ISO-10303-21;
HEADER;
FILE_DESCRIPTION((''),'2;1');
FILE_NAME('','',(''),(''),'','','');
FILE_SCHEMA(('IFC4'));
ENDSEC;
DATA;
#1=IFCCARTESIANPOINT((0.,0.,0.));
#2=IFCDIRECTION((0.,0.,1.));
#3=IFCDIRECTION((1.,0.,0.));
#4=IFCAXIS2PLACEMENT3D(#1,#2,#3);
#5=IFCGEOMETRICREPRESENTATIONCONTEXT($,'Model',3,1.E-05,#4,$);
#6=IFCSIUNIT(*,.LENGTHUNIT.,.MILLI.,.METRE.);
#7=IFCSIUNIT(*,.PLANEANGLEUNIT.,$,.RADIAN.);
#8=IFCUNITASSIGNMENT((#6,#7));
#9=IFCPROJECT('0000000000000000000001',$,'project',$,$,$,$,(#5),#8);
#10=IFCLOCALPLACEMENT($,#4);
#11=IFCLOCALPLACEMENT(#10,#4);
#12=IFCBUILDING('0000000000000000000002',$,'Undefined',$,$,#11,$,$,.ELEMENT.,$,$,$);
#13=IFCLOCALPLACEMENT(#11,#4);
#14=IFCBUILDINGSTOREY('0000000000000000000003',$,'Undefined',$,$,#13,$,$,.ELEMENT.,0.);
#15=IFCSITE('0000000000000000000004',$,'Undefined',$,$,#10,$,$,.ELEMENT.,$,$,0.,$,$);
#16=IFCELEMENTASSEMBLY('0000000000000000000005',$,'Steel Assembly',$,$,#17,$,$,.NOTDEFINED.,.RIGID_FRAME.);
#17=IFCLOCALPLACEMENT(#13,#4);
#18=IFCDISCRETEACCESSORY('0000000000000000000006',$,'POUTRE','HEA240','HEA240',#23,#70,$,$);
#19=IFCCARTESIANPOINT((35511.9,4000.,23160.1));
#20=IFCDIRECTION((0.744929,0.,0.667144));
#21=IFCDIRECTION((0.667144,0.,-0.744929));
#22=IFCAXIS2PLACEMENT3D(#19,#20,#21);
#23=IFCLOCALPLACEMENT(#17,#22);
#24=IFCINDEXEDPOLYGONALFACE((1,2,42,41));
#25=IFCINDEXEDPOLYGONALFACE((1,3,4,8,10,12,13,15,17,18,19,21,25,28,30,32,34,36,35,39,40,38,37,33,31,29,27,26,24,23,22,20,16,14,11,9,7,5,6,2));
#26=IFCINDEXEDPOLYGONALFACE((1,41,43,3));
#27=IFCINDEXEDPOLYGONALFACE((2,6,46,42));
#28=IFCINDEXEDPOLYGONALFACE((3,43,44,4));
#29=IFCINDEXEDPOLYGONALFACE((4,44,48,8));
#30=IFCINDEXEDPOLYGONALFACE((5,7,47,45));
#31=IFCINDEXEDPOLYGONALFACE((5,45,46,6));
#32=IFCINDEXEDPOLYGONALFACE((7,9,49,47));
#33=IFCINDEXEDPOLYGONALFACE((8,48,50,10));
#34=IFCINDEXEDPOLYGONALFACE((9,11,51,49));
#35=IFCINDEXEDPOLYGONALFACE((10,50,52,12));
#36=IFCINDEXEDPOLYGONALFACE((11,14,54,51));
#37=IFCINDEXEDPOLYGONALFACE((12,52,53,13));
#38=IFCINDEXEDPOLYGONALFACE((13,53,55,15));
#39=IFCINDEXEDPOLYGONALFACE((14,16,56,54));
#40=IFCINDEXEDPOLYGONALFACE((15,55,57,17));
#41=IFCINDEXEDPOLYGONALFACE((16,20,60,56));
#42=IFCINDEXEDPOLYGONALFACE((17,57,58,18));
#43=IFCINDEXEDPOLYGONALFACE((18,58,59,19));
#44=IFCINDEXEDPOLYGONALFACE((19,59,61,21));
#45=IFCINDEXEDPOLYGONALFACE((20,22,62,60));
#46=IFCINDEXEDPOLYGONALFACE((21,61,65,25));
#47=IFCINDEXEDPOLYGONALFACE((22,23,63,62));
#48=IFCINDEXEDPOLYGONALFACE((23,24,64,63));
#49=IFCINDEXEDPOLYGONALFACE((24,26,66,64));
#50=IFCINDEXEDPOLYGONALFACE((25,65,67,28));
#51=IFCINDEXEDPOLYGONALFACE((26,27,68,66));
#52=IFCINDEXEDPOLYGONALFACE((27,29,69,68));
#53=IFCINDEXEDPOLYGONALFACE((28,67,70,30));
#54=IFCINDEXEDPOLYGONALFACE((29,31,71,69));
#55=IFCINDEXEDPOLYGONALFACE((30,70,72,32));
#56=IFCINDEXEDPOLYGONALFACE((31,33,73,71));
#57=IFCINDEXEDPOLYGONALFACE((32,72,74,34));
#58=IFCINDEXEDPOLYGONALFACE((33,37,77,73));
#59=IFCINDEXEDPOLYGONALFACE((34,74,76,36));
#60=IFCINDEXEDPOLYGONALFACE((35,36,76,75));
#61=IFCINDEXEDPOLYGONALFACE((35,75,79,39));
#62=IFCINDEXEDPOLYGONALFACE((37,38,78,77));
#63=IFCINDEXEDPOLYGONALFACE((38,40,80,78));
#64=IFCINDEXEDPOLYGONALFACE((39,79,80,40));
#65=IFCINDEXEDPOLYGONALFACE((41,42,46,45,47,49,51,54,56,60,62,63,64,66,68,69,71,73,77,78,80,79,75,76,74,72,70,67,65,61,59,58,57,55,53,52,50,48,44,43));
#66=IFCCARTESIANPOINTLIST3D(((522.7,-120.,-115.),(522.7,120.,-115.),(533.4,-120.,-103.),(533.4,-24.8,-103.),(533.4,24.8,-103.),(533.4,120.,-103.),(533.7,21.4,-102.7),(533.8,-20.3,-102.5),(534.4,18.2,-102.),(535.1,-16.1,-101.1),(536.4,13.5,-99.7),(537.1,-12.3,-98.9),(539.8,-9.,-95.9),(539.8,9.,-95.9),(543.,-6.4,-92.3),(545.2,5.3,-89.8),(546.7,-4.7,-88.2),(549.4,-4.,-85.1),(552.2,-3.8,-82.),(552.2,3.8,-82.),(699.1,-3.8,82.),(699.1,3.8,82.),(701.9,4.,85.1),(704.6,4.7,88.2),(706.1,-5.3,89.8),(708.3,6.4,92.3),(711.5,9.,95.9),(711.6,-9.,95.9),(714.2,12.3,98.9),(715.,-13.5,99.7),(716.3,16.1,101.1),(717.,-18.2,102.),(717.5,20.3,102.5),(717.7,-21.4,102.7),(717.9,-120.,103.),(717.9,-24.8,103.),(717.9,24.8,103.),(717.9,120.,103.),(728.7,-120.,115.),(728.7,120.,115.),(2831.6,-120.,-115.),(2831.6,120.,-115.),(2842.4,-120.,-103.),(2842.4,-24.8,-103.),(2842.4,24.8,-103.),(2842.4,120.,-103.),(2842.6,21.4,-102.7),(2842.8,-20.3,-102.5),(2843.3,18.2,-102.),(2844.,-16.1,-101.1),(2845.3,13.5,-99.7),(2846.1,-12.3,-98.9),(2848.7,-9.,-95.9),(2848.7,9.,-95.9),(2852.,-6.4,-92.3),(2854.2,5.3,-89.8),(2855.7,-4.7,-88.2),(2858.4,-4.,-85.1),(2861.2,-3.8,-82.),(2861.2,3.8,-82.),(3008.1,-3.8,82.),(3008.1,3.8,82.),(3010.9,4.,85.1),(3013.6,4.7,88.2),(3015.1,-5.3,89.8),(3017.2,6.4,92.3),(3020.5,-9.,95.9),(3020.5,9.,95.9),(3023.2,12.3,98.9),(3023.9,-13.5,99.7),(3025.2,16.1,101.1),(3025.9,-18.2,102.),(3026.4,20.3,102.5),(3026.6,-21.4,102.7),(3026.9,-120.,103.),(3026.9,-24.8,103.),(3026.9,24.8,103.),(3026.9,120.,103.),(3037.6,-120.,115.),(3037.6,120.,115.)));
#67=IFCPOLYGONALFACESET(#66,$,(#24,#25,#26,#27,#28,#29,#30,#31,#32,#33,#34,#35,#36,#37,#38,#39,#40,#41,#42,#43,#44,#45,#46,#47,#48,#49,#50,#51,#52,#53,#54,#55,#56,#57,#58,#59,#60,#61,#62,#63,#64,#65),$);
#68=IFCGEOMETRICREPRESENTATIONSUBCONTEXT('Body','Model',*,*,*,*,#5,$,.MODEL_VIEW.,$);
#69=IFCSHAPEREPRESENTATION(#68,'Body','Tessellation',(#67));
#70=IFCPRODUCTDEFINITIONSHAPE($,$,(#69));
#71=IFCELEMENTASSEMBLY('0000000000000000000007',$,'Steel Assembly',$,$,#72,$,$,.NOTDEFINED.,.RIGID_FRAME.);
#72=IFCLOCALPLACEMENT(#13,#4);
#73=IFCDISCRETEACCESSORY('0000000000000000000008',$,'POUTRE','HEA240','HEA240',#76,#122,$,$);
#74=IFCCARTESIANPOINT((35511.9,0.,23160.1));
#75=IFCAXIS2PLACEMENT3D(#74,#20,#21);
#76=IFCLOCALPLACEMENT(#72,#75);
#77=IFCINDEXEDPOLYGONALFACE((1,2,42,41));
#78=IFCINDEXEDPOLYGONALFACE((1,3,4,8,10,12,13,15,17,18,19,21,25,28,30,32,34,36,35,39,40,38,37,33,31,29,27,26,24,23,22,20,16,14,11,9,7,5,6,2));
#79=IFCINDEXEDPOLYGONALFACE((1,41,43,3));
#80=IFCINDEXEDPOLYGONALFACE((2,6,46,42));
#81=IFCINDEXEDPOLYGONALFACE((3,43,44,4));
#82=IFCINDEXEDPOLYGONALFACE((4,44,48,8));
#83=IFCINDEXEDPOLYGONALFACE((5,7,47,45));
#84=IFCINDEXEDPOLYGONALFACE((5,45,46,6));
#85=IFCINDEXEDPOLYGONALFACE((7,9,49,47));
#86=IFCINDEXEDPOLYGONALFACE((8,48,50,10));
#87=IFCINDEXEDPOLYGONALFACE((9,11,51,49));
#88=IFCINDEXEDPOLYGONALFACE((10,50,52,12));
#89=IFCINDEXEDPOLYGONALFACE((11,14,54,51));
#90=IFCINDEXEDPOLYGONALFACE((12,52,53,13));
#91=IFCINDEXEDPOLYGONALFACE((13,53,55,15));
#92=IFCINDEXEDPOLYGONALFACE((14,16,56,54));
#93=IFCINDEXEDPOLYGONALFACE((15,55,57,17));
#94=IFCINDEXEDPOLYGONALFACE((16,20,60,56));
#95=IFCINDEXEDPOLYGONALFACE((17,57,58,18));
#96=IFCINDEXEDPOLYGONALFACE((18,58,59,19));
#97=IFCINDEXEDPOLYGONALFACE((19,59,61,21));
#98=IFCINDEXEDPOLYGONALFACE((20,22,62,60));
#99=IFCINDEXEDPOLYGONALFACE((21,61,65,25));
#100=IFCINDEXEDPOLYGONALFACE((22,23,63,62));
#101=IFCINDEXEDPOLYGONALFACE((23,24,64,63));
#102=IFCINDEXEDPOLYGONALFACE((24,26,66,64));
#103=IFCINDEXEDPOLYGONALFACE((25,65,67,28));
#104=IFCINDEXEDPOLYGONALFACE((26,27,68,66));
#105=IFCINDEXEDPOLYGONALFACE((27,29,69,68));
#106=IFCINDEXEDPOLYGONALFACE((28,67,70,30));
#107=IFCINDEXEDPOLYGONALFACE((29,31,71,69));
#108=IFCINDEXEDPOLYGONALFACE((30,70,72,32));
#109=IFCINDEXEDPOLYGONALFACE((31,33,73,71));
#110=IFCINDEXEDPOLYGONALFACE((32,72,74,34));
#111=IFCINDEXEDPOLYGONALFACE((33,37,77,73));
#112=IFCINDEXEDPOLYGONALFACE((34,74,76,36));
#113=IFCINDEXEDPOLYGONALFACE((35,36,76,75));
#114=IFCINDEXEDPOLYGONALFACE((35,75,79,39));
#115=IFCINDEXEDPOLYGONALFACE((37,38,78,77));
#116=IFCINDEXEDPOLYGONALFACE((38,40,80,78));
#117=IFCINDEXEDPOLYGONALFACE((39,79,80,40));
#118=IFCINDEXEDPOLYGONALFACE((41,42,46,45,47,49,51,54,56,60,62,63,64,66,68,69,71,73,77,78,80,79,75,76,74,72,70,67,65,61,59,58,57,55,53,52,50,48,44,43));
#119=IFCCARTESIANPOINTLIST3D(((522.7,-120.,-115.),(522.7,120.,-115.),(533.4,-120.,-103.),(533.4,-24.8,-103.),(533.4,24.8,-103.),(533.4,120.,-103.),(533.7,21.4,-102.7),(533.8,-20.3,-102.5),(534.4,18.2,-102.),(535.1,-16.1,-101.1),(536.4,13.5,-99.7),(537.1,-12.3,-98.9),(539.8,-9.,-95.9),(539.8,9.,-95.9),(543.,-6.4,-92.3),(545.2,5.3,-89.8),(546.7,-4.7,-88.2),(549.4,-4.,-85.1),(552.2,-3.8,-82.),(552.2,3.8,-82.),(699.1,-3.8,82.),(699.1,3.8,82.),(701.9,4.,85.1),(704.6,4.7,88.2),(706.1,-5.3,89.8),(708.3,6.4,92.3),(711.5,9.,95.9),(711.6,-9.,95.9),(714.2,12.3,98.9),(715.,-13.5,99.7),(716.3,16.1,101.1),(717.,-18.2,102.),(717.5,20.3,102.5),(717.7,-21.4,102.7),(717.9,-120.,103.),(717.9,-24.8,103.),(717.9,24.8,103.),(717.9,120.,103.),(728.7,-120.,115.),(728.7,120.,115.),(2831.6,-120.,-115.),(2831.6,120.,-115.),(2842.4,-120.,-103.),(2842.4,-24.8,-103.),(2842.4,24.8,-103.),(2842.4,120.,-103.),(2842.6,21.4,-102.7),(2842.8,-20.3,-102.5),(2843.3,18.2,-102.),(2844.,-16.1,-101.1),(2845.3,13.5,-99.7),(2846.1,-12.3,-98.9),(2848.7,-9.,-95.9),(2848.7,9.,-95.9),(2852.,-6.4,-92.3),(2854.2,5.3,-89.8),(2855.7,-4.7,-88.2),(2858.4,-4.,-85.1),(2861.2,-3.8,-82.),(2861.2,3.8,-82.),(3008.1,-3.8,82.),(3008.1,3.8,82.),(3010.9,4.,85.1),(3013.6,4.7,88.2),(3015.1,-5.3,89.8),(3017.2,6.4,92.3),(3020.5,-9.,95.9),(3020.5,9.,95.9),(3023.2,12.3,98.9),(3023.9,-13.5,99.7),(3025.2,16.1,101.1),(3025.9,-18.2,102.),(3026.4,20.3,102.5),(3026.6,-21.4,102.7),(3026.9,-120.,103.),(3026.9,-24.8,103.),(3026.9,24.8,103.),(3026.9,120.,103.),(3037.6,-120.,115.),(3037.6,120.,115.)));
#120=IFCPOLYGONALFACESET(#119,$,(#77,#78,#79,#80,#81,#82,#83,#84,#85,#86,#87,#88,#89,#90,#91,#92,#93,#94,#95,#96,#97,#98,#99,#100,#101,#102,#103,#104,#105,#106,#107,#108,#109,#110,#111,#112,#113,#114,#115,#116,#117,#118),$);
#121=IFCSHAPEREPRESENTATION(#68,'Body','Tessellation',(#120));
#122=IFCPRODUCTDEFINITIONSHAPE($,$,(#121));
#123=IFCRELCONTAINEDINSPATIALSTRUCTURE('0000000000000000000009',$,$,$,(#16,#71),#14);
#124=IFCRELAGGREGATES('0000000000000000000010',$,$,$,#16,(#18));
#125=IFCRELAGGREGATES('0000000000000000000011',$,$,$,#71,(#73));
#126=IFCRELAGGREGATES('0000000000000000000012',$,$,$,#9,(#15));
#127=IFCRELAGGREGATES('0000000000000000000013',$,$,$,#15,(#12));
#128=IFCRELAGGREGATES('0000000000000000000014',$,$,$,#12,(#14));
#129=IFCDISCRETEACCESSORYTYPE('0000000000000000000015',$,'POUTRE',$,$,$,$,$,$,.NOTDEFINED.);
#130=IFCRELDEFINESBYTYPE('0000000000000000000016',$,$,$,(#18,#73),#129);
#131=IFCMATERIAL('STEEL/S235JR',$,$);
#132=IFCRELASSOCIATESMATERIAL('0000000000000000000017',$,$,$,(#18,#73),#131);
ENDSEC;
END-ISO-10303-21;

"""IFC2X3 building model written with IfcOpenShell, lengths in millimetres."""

from ifc_helpers import new_model, si_unit, frame, origin_with_axes, origin_2d_with_axis, place, context, subcontext, project, spatial, i_section, extrude, clip, halfspace, material, type_object, element, aggregate, save


model = new_model("IFC2X3")

# Units and contexts
model_context = context("Model", 3, precision=1e-05, world=origin_with_axes())
body_context = subcontext(model_context, "Body", "Model", "MODEL_VIEW")
ifc_project = project(units=[si_unit("LENGTHUNIT", "METRE", prefix="MILLI"), si_unit("PLANEANGLEUNIT", "RADIAN")], contexts=[model_context])

# Site, building, storey
site_placement = place(None, origin_with_axes())
site = spatial("IfcSite", under=ifc_project, at=site_placement, Name="Undefined", CompositionType="ELEMENT", RefElevation=0.0)
building_placement = place(site_placement, origin_with_axes())
building = spatial("IfcBuilding", under=site, at=building_placement, Name="Undefined", CompositionType="ELEMENT")
storey_placement = place(building_placement, origin_with_axes())
storey = spatial("IfcBuildingStorey", under=building, at=storey_placement, Name="Undefined", CompositionType="ELEMENT", Elevation=0.0)

# Shared definitions
ifc_material_1 = material(Name="STEEL/S235JR")

# Element assemblies, discrete accessories
assembly_1_placement = place(storey_placement, origin_with_axes())
assembly_1 = element("IfcElementAssembly", 1, at=assembly_1_placement, inside=storey, Name="Steel Assembly", AssemblyPlace="NOTDEFINED", PredefinedType="RIGID_FRAME")
discrete_accessory_type_1 = type_object("IfcDiscreteAccessoryType", Name="POUTRE")
discrete_accessory_1_placement = place(assembly_1_placement, frame((35511.9, 4000.0, 23160.1), z_axis=(0.744929, 0.0, 0.667144), x_axis=(0.667144, 0.0, -0.744929)))
discrete_accessory_1 = element("IfcDiscreteAccessory", 2, at=discrete_accessory_1_placement, type_object=discrete_accessory_type_1, material=ifc_material_1, Name="POUTRE", Description="HEA240", ObjectType="HEA240", context=body_context, shape_type="Clipping", body=[
    clip(clip(extrude(i_section(OverallWidth=240.0, OverallDepth=230.0, WebThickness=7.5, FlangeThickness=12.0, FilletRadius=21.0, at=origin_2d_with_axis()), frame((3142.7, 0.0, 0.0), z_axis=(-1.0, 0.0, 0.0), x_axis=(0.0, -1.0, 0.0)), (0.0, 0.0, 1.0), 2725.0), halfspace(frame((2782.3, 0.0, -170.1), z_axis=(0.744929, 0.0, -0.667144), x_axis=(0.0, -1.0, 0.0)), False)), halfspace(frame((522.7, 0.0, -115.0), z_axis=(0.744929, 0.0, -0.667144), x_axis=(0.0, -1.0, 0.0)), True)),
])
aggregate(assembly_1, [discrete_accessory_1])
assembly_2_placement = place(storey_placement, origin_with_axes())
assembly_2 = element("IfcElementAssembly", 3, at=assembly_2_placement, inside=storey, Name="Steel Assembly", AssemblyPlace="NOTDEFINED", PredefinedType="RIGID_FRAME")
discrete_accessory_2_placement = place(assembly_2_placement, frame((35511.9, 0.0, 23160.1), z_axis=(0.744929, 0.0, 0.667144), x_axis=(0.667144, 0.0, -0.744929)))
discrete_accessory_2 = element("IfcDiscreteAccessory", 4, at=discrete_accessory_2_placement, type_object=discrete_accessory_type_1, material=ifc_material_1, Name="POUTRE", Description="HEA240", ObjectType="HEA240", context=body_context, shape_type="Clipping", body=[
    clip(clip(extrude(i_section(OverallWidth=240.0, OverallDepth=230.0, WebThickness=7.5, FlangeThickness=12.0, FilletRadius=21.0, at=origin_2d_with_axis()), frame((3142.7, 0.0, 0.0), z_axis=(-1.0, 0.0, 0.0), x_axis=(0.0, -1.0, 0.0)), (0.0, 0.0, 1.0), 2725.0), halfspace(frame((2782.3, 0.0, -170.1), z_axis=(0.744929, 0.0, -0.667144), x_axis=(0.0, -1.0, 0.0)), False)), halfspace(frame((522.7, 0.0, -115.0), z_axis=(0.744929, 0.0, -0.667144), x_axis=(0.0, -1.0, 0.0)), True)),
])
aggregate(assembly_2, [discrete_accessory_2])

save(model, "model.ifc")
